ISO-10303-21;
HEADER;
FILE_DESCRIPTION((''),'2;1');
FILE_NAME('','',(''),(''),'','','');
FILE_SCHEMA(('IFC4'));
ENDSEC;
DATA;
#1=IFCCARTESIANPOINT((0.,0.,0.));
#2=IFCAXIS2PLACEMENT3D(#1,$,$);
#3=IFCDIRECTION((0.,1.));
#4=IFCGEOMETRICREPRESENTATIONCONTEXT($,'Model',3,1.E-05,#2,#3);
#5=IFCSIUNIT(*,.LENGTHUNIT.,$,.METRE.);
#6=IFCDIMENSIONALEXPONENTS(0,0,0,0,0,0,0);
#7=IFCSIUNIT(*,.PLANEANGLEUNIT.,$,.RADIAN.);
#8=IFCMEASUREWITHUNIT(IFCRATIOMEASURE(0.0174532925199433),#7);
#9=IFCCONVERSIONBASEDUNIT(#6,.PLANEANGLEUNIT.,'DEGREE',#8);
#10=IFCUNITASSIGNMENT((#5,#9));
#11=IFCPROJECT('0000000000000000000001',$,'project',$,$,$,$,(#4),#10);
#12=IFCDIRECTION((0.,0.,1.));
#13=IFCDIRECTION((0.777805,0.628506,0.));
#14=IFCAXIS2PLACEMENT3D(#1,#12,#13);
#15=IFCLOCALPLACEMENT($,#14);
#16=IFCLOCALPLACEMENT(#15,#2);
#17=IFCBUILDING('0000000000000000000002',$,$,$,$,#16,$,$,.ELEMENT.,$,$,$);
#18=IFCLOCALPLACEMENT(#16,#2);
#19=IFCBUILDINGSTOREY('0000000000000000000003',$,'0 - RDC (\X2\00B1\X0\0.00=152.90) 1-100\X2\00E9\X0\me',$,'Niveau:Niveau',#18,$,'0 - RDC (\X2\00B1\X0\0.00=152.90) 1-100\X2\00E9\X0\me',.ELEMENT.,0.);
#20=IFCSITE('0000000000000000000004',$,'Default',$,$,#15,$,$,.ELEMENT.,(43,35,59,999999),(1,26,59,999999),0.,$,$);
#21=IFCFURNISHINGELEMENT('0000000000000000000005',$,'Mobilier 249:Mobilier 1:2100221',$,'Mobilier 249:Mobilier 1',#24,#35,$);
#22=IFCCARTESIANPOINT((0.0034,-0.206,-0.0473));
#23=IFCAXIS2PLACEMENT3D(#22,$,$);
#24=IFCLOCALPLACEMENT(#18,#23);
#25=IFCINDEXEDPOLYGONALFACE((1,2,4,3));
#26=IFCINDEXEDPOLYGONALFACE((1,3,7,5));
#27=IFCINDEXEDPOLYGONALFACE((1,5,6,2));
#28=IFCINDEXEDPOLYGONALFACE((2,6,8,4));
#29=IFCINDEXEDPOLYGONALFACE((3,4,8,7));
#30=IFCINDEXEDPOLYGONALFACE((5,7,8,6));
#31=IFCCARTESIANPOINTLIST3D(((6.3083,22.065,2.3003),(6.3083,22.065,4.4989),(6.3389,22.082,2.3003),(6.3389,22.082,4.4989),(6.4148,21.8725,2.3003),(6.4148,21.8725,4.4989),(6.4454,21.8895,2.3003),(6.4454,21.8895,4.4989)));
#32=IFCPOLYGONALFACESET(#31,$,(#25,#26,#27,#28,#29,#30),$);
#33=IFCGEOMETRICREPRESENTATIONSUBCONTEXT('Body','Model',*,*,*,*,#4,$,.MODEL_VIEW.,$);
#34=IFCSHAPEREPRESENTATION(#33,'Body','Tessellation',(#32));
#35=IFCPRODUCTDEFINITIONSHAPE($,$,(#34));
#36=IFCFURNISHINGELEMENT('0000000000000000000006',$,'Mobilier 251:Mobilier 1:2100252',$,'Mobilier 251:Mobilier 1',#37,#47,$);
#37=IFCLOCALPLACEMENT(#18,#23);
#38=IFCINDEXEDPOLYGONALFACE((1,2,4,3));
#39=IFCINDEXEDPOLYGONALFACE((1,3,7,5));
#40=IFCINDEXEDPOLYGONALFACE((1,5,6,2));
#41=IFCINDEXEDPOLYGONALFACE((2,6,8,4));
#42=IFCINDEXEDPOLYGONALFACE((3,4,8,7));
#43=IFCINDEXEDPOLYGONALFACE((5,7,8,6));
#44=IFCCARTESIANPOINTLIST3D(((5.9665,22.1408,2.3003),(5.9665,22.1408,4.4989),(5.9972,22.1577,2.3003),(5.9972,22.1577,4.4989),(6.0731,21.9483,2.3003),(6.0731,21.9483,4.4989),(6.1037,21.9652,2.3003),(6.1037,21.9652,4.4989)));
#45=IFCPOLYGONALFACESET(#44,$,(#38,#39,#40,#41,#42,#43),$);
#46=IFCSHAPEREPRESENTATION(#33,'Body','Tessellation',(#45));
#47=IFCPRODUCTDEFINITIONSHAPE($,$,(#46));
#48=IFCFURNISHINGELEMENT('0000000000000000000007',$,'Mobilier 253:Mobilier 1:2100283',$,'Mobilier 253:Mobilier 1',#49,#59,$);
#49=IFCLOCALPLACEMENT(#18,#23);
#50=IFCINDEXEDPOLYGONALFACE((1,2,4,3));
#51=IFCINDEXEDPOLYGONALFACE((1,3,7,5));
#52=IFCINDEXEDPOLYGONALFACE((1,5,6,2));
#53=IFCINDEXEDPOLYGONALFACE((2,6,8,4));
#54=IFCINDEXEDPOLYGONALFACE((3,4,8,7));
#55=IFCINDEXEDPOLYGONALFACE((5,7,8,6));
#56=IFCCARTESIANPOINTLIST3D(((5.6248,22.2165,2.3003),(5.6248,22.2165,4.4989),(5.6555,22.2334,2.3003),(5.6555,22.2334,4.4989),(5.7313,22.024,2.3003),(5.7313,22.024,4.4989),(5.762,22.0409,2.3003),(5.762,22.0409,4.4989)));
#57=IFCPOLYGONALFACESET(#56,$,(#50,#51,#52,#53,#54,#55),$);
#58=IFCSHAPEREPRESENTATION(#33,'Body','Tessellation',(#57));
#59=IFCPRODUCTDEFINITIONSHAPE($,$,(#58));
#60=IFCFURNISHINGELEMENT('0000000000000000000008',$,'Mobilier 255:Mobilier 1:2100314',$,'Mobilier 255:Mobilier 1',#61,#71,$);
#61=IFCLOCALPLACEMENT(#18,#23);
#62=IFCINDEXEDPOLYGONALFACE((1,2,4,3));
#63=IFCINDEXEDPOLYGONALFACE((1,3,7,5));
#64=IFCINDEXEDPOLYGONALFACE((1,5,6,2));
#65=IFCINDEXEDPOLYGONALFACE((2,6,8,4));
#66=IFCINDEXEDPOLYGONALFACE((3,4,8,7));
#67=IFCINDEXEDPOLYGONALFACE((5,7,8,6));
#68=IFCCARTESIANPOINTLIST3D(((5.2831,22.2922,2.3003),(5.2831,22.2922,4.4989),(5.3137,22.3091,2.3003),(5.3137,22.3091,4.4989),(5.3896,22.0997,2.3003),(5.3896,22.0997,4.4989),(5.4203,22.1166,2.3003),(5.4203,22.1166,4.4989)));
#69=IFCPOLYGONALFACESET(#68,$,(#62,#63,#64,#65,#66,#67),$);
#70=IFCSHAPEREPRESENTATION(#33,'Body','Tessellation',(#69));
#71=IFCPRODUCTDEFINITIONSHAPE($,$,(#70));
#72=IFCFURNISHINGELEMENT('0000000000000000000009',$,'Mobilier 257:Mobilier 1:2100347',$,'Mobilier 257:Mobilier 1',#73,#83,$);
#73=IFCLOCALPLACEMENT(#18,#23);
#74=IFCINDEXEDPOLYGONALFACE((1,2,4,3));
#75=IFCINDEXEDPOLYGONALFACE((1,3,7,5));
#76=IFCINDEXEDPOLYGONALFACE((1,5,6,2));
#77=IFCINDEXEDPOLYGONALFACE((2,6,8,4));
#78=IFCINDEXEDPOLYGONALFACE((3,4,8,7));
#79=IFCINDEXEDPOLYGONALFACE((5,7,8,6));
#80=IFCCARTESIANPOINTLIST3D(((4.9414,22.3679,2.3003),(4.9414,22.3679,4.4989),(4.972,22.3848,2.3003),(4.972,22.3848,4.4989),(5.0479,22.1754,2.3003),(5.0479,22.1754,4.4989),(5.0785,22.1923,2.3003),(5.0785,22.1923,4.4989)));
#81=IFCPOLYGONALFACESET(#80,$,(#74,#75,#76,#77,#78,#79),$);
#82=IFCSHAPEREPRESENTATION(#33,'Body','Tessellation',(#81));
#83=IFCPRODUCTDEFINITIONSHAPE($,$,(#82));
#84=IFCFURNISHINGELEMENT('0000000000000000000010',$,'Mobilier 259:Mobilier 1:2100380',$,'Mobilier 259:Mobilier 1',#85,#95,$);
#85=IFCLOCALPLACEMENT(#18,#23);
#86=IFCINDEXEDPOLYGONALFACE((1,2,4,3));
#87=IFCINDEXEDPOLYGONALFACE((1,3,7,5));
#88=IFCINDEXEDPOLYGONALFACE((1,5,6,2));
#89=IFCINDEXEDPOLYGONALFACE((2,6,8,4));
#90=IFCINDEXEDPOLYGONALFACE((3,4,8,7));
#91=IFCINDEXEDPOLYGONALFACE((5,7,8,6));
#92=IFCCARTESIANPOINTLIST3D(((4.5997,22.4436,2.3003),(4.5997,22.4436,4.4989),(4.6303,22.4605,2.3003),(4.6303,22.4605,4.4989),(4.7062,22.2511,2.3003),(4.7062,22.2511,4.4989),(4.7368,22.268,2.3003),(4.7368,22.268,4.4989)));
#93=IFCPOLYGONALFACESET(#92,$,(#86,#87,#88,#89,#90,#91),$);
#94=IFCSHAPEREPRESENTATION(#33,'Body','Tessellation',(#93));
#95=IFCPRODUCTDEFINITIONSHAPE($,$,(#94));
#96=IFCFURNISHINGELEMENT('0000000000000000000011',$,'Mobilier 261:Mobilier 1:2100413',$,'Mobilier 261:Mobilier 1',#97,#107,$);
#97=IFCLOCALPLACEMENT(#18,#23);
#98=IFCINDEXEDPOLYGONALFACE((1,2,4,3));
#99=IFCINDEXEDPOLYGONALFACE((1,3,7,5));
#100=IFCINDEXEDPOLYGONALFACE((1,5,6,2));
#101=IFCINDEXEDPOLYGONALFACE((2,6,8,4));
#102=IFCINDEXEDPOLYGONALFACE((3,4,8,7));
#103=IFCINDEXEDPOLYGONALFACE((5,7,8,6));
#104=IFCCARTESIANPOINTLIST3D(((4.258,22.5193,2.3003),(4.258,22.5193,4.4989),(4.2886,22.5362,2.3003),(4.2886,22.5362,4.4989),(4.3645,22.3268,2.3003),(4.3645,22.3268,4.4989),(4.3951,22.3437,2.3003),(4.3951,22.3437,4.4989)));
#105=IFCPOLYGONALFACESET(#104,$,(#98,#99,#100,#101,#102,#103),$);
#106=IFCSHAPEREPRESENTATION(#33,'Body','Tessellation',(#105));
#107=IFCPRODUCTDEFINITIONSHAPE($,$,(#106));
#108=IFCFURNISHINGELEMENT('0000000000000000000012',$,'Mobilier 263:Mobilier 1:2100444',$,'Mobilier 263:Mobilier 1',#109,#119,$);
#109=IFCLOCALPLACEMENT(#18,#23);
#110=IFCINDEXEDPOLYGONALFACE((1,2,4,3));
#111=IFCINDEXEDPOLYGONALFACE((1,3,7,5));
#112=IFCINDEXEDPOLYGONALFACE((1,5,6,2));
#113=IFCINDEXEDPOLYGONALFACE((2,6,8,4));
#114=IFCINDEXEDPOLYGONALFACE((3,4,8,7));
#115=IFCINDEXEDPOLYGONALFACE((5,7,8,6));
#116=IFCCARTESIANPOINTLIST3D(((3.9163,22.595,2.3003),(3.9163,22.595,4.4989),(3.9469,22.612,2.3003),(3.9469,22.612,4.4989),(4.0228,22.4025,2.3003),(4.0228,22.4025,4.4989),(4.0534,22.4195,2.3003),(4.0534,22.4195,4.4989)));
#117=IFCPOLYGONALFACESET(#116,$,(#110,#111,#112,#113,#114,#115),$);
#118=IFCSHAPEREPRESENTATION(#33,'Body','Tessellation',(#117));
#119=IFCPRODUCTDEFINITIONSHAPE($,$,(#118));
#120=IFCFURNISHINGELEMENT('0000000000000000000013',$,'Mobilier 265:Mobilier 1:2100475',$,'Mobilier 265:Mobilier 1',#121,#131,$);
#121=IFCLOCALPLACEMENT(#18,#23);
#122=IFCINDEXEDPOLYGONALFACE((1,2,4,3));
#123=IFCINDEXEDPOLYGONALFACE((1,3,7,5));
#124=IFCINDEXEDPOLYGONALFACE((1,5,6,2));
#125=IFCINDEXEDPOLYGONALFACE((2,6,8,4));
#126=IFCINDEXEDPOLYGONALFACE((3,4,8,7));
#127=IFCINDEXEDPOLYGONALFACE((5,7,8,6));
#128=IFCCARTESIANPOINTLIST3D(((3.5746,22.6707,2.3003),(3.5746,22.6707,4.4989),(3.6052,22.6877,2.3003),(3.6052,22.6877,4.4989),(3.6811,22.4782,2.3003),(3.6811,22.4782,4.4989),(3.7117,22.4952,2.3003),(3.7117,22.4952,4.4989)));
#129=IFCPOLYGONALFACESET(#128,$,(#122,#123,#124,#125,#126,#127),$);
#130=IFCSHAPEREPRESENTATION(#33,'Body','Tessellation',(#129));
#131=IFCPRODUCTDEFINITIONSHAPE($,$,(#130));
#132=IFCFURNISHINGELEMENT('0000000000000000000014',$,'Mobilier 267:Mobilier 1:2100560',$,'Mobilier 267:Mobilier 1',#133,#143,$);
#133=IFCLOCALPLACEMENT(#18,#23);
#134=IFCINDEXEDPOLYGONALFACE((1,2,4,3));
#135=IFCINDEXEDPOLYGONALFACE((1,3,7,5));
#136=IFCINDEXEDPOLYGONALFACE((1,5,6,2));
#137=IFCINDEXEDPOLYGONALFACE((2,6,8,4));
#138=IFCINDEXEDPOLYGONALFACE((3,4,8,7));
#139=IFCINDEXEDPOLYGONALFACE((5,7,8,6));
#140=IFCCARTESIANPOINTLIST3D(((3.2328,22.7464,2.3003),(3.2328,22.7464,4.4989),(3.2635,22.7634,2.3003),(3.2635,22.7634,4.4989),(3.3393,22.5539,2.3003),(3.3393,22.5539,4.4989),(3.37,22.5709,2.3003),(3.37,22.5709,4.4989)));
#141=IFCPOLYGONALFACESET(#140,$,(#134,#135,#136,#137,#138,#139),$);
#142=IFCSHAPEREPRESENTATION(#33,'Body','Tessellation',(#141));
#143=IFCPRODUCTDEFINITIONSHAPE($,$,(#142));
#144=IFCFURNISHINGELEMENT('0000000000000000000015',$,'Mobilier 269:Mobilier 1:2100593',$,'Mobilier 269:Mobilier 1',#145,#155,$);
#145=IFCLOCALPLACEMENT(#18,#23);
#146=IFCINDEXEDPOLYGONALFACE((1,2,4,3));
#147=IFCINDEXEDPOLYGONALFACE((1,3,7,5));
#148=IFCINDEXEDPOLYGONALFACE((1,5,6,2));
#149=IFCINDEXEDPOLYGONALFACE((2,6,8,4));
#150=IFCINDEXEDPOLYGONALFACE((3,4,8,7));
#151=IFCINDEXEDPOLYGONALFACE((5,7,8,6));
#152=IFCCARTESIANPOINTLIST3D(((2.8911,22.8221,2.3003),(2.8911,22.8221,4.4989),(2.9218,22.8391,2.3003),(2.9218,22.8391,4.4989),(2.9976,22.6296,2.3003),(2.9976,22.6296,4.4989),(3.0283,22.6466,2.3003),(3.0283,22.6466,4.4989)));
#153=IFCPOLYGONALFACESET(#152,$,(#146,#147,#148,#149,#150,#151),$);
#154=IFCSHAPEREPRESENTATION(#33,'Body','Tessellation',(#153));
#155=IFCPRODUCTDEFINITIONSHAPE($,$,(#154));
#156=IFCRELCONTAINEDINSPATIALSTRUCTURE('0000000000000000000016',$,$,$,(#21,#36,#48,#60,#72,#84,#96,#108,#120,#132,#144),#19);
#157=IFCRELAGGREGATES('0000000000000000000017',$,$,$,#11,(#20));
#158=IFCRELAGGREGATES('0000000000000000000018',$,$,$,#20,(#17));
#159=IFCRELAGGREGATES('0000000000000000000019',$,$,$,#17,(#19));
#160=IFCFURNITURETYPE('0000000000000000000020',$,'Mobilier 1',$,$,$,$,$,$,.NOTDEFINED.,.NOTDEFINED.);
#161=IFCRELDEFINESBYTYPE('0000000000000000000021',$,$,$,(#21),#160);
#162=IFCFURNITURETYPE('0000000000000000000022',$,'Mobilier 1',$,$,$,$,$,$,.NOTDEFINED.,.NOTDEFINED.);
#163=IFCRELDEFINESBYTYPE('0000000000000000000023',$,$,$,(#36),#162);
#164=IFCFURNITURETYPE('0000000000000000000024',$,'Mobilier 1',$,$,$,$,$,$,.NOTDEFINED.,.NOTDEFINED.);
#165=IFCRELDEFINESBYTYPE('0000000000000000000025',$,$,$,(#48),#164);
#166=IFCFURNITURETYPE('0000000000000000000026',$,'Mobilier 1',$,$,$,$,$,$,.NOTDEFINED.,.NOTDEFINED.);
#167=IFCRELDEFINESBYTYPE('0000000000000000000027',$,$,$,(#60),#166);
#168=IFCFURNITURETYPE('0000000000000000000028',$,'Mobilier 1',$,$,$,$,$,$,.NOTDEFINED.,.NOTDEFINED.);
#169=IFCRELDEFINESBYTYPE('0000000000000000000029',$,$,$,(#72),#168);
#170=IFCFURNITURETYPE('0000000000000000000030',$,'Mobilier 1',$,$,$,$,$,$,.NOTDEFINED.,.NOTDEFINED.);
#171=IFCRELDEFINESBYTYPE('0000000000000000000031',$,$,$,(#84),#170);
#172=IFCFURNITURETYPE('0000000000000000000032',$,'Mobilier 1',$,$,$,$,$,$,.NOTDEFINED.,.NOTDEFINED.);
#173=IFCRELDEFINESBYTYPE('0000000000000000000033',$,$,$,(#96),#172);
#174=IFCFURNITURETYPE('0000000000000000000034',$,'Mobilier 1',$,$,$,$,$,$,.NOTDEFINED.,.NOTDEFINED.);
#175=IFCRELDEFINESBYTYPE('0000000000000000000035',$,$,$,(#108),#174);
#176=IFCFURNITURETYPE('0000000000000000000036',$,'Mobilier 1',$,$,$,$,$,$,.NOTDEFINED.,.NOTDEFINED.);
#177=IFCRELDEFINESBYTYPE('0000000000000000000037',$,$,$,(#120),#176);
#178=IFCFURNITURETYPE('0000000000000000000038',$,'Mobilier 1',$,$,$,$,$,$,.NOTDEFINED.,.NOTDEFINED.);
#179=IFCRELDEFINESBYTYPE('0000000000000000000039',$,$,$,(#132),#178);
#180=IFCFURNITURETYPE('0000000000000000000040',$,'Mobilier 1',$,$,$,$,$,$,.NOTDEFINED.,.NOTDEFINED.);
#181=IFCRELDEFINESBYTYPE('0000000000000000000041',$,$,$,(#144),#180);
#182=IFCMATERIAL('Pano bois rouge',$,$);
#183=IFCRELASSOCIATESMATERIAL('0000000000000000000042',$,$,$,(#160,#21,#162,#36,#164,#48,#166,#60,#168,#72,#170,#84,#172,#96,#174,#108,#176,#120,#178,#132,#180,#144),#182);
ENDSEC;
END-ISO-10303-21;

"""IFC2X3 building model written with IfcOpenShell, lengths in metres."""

from ifc_helpers import new_model, entity, si_unit, converted_unit, direction, frame, frame_2d, origin, origin_2d_with_axis, place, context, subcontext, project, spatial, rectangle, extrude, source, transform, mapped, material, type_object, type_shapes, element, save


model = new_model("IFC2X3")

# Units and contexts
model_context = context("Model", 3, precision=1e-05, world=origin(), true_north=direction((0.0, 1.0)))
body_context = subcontext(model_context, "Body", "Model", "MODEL_VIEW")
ifc_project = project(units=[si_unit("LENGTHUNIT", "METRE"), converted_unit("PLANEANGLEUNIT", "DEGREE", entity("IfcRatioMeasure", 0.0174532925199433), si_unit("PLANEANGLEUNIT", "RADIAN"), dimensions=[0, 0, 0, 0, 0, 0, 0])], contexts=[model_context])

# Site, building, storey
site_placement = place(None, frame((0.0, 0.0, 0.0), z_axis=(0.0, 0.0, 1.0), x_axis=(0.777805, 0.628506, 0.0)))
site = spatial("IfcSite", under=ifc_project, at=site_placement, Name="Default", CompositionType="ELEMENT", RefLatitude=(43, 35, 59, 999999), RefLongitude=(1, 26, 59, 999999), RefElevation=0.0)
building_placement = place(site_placement, origin())
building = spatial("IfcBuilding", under=site, at=building_placement, CompositionType="ELEMENT")
storey_placement = place(building_placement, origin())
storey = spatial("IfcBuildingStorey", under=building, at=storey_placement, Name="0 - RDC (±0.00=152.90) 1-100éme", ObjectType="Niveau:Niveau", LongName="0 - RDC (±0.00=152.90) 1-100éme", CompositionType="ELEMENT", Elevation=0.0)

# Furnishing elements
ifc_material_1 = material(Name="Pano bois rouge")
furniture_type_1 = type_object("IfcFurnitureType", Name="Mobilier 1", material=ifc_material_1)
shared_shape_1 = source(origin(), body_context, "Body", "SweptSolid", [
    extrude(rectangle(XDim=0.035, YDim=0.22, at=origin_2d_with_axis()), frame((6.3768, 21.9773, 2.3003), z_axis=(0.0, 0.0, 1.0), x_axis=(-0.875002, -0.484119, 0.0)), (0.0, 0.0, 1.0), 2.1986),
])
type_shapes(furniture_type_1, [shared_shape_1])
furnishing_1_placement = place(storey_placement, frame((0.0034, -0.206, -0.0473)))
element("IfcFurnishingElement", 1, at=furnishing_1_placement, inside=storey, type_object=furniture_type_1, material=ifc_material_1, Name="Mobilier 249:Mobilier 1:2100221", ObjectType="Mobilier 249:Mobilier 1", context=body_context, shape_type="MappedRepresentation", body=[
    mapped(shared_shape_1, transform((0.0, 0.0, 0.0), scale=1.0)),
])
furniture_type_2 = type_object("IfcFurnitureType", Name="Mobilier 1", material=ifc_material_1)
shared_shape_2 = source(origin(), body_context, "Body", "SweptSolid", [
    extrude(rectangle(XDim=0.035, YDim=0.22, at=frame_2d((0.0, 0.0), x_axis=(1.0, 0.0))), frame((6.0351, 22.053, 2.3003), z_axis=(0.0, 0.0, 1.0), x_axis=(-0.875002, -0.484119, 0.0)), (0.0, 0.0, 1.0), 2.1986),
])
type_shapes(furniture_type_2, [shared_shape_2])
furnishing_2_placement = place(storey_placement, frame((0.0034, -0.206, -0.0473)))
element("IfcFurnishingElement", 2, at=furnishing_2_placement, inside=storey, type_object=furniture_type_2, material=ifc_material_1, Name="Mobilier 251:Mobilier 1:2100252", ObjectType="Mobilier 251:Mobilier 1", context=body_context, shape_type="MappedRepresentation", body=[
    mapped(shared_shape_2, transform((0.0, 0.0, 0.0), scale=1.0)),
])
furniture_type_3 = type_object("IfcFurnitureType", Name="Mobilier 1", material=ifc_material_1)
shared_shape_3 = source(origin(), body_context, "Body", "SweptSolid", [
    extrude(rectangle(XDim=0.035, YDim=0.22, at=frame_2d((0.0, 0.0), x_axis=(1.0, 0.0))), frame((5.6934, 22.1287, 2.3003), z_axis=(0.0, 0.0, 1.0), x_axis=(-0.875002, -0.484119, 0.0)), (0.0, 0.0, 1.0), 2.1986),
])
type_shapes(furniture_type_3, [shared_shape_3])
furnishing_3_placement = place(storey_placement, frame((0.0034, -0.206, -0.0473)))
element("IfcFurnishingElement", 3, at=furnishing_3_placement, inside=storey, type_object=furniture_type_3, material=ifc_material_1, Name="Mobilier 253:Mobilier 1:2100283", ObjectType="Mobilier 253:Mobilier 1", context=body_context, shape_type="MappedRepresentation", body=[
    mapped(shared_shape_3, transform((0.0, 0.0, 0.0), scale=1.0)),
])
furniture_type_4 = type_object("IfcFurnitureType", Name="Mobilier 1", material=ifc_material_1)
shared_shape_4 = source(origin(), body_context, "Body", "SweptSolid", [
    extrude(rectangle(XDim=0.035, YDim=0.22, at=origin_2d_with_axis()), frame((5.3517, 22.2044, 2.3003), z_axis=(0.0, 0.0, 1.0), x_axis=(-0.875002, -0.484119, 0.0)), (0.0, 0.0, 1.0), 2.1986),
])
type_shapes(furniture_type_4, [shared_shape_4])
furnishing_4_placement = place(storey_placement, frame((0.0034, -0.206, -0.0473)))
element("IfcFurnishingElement", 4, at=furnishing_4_placement, inside=storey, type_object=furniture_type_4, material=ifc_material_1, Name="Mobilier 255:Mobilier 1:2100314", ObjectType="Mobilier 255:Mobilier 1", context=body_context, shape_type="MappedRepresentation", body=[
    mapped(shared_shape_4, transform((0.0, 0.0, 0.0), scale=1.0)),
])
furniture_type_5 = type_object("IfcFurnitureType", Name="Mobilier 1", material=ifc_material_1)
shared_shape_5 = source(origin(), body_context, "Body", "SweptSolid", [
    extrude(rectangle(XDim=0.035, YDim=0.22, at=frame_2d((0.0, 0.0), x_axis=(1.0, 0.0))), frame((5.01, 22.2801, 2.3003), z_axis=(0.0, 0.0, 1.0), x_axis=(-0.875002, -0.484119, 0.0)), (0.0, 0.0, 1.0), 2.1986),
])
type_shapes(furniture_type_5, [shared_shape_5])
furnishing_5_placement = place(storey_placement, frame((0.0034, -0.206, -0.0473)))
element("IfcFurnishingElement", 5, at=furnishing_5_placement, inside=storey, type_object=furniture_type_5, material=ifc_material_1, Name="Mobilier 257:Mobilier 1:2100347", ObjectType="Mobilier 257:Mobilier 1", context=body_context, shape_type="MappedRepresentation", body=[
    mapped(shared_shape_5, transform((0.0, 0.0, 0.0), scale=1.0)),
])
furniture_type_6 = type_object("IfcFurnitureType", Name="Mobilier 1", material=ifc_material_1)
shared_shape_6 = source(origin(), body_context, "Body", "SweptSolid", [
    extrude(rectangle(XDim=0.035, YDim=0.22, at=origin_2d_with_axis()), frame((4.6683, 22.3558, 2.3003), z_axis=(0.0, 0.0, 1.0), x_axis=(-0.875002, -0.484119, 0.0)), (0.0, 0.0, 1.0), 2.1986),
])
type_shapes(furniture_type_6, [shared_shape_6])
furnishing_6_placement = place(storey_placement, frame((0.0034, -0.206, -0.0473)))
element("IfcFurnishingElement", 6, at=furnishing_6_placement, inside=storey, type_object=furniture_type_6, material=ifc_material_1, Name="Mobilier 259:Mobilier 1:2100380", ObjectType="Mobilier 259:Mobilier 1", context=body_context, shape_type="MappedRepresentation", body=[
    mapped(shared_shape_6, transform((0.0, 0.0, 0.0), scale=1.0)),
])
furniture_type_7 = type_object("IfcFurnitureType", Name="Mobilier 1", material=ifc_material_1)
shared_shape_7 = source(origin(), body_context, "Body", "SweptSolid", [
    extrude(rectangle(XDim=0.035, YDim=0.22, at=origin_2d_with_axis()), frame((4.3265, 22.4315, 2.3003), z_axis=(0.0, 0.0, 1.0), x_axis=(-0.875002, -0.484119, 0.0)), (0.0, 0.0, 1.0), 2.1986),
])
type_shapes(furniture_type_7, [shared_shape_7])
furnishing_7_placement = place(storey_placement, frame((0.0034, -0.206, -0.0473)))
element("IfcFurnishingElement", 7, at=furnishing_7_placement, inside=storey, type_object=furniture_type_7, material=ifc_material_1, Name="Mobilier 261:Mobilier 1:2100413", ObjectType="Mobilier 261:Mobilier 1", context=body_context, shape_type="MappedRepresentation", body=[
    mapped(shared_shape_7, transform((0.0, 0.0, 0.0), scale=1.0)),
])
furniture_type_8 = type_object("IfcFurnitureType", Name="Mobilier 1", material=ifc_material_1)
shared_shape_8 = source(origin(), body_context, "Body", "SweptSolid", [
    extrude(rectangle(XDim=0.035, YDim=0.22, at=frame_2d((0.0, 0.0), x_axis=(1.0, 0.0))), frame((3.9848, 22.5072, 2.3003), z_axis=(0.0, 0.0, 1.0), x_axis=(-0.875002, -0.484119, 0.0)), (0.0, 0.0, 1.0), 2.1986),
])
type_shapes(furniture_type_8, [shared_shape_8])
furnishing_8_placement = place(storey_placement, frame((0.0034, -0.206, -0.0473)))
element("IfcFurnishingElement", 8, at=furnishing_8_placement, inside=storey, type_object=furniture_type_8, material=ifc_material_1, Name="Mobilier 263:Mobilier 1:2100444", ObjectType="Mobilier 263:Mobilier 1", context=body_context, shape_type="MappedRepresentation", body=[
    mapped(shared_shape_8, transform((0.0, 0.0, 0.0), scale=1.0)),
])
furniture_type_9 = type_object("IfcFurnitureType", Name="Mobilier 1", material=ifc_material_1)
shared_shape_9 = source(origin(), body_context, "Body", "SweptSolid", [
    extrude(rectangle(XDim=0.035, YDim=0.22, at=origin_2d_with_axis()), frame((3.6431, 22.5829, 2.3003), z_axis=(0.0, 0.0, 1.0), x_axis=(-0.875002, -0.484119, 0.0)), (0.0, 0.0, 1.0), 2.1986),
])
type_shapes(furniture_type_9, [shared_shape_9])
furnishing_9_placement = place(storey_placement, frame((0.0034, -0.206, -0.0473)))
element("IfcFurnishingElement", 9, at=furnishing_9_placement, inside=storey, type_object=furniture_type_9, material=ifc_material_1, Name="Mobilier 265:Mobilier 1:2100475", ObjectType="Mobilier 265:Mobilier 1", context=body_context, shape_type="MappedRepresentation", body=[
    mapped(shared_shape_9, transform((0.0, 0.0, 0.0), scale=1.0)),
])
furniture_type_10 = type_object("IfcFurnitureType", Name="Mobilier 1", material=ifc_material_1)
shared_shape_10 = source(origin(), body_context, "Body", "SweptSolid", [
    extrude(rectangle(XDim=0.035, YDim=0.22, at=frame_2d((0.0, 0.0), x_axis=(1.0, 0.0))), frame((3.3014, 22.6587, 2.3003), z_axis=(0.0, 0.0, 1.0), x_axis=(-0.875002, -0.484119, 0.0)), (0.0, 0.0, 1.0), 2.1986),
])
type_shapes(furniture_type_10, [shared_shape_10])
furnishing_10_placement = place(storey_placement, frame((0.0034, -0.206, -0.0473)))
element("IfcFurnishingElement", 10, at=furnishing_10_placement, inside=storey, type_object=furniture_type_10, material=ifc_material_1, Name="Mobilier 267:Mobilier 1:2100560", ObjectType="Mobilier 267:Mobilier 1", context=body_context, shape_type="MappedRepresentation", body=[
    mapped(shared_shape_10, transform((0.0, 0.0, 0.0), scale=1.0)),
])
furniture_type_11 = type_object("IfcFurnitureType", Name="Mobilier 1", material=ifc_material_1)
shared_shape_11 = source(origin(), body_context, "Body", "SweptSolid", [
    extrude(rectangle(XDim=0.035, YDim=0.22, at=origin_2d_with_axis()), frame((2.9597, 22.7344, 2.3003), z_axis=(0.0, 0.0, 1.0), x_axis=(-0.875002, -0.484119, 0.0)), (0.0, 0.0, 1.0), 2.1986),
])
type_shapes(furniture_type_11, [shared_shape_11])
furnishing_11_placement = place(storey_placement, frame((0.0034, -0.206, -0.0473)))
element("IfcFurnishingElement", 11, at=furnishing_11_placement, inside=storey, type_object=furniture_type_11, material=ifc_material_1, Name="Mobilier 269:Mobilier 1:2100593", ObjectType="Mobilier 269:Mobilier 1", context=body_context, shape_type="MappedRepresentation", body=[
    mapped(shared_shape_11, transform((0.0, 0.0, 0.0), scale=1.0)),
])

save(model, "model.ifc")
